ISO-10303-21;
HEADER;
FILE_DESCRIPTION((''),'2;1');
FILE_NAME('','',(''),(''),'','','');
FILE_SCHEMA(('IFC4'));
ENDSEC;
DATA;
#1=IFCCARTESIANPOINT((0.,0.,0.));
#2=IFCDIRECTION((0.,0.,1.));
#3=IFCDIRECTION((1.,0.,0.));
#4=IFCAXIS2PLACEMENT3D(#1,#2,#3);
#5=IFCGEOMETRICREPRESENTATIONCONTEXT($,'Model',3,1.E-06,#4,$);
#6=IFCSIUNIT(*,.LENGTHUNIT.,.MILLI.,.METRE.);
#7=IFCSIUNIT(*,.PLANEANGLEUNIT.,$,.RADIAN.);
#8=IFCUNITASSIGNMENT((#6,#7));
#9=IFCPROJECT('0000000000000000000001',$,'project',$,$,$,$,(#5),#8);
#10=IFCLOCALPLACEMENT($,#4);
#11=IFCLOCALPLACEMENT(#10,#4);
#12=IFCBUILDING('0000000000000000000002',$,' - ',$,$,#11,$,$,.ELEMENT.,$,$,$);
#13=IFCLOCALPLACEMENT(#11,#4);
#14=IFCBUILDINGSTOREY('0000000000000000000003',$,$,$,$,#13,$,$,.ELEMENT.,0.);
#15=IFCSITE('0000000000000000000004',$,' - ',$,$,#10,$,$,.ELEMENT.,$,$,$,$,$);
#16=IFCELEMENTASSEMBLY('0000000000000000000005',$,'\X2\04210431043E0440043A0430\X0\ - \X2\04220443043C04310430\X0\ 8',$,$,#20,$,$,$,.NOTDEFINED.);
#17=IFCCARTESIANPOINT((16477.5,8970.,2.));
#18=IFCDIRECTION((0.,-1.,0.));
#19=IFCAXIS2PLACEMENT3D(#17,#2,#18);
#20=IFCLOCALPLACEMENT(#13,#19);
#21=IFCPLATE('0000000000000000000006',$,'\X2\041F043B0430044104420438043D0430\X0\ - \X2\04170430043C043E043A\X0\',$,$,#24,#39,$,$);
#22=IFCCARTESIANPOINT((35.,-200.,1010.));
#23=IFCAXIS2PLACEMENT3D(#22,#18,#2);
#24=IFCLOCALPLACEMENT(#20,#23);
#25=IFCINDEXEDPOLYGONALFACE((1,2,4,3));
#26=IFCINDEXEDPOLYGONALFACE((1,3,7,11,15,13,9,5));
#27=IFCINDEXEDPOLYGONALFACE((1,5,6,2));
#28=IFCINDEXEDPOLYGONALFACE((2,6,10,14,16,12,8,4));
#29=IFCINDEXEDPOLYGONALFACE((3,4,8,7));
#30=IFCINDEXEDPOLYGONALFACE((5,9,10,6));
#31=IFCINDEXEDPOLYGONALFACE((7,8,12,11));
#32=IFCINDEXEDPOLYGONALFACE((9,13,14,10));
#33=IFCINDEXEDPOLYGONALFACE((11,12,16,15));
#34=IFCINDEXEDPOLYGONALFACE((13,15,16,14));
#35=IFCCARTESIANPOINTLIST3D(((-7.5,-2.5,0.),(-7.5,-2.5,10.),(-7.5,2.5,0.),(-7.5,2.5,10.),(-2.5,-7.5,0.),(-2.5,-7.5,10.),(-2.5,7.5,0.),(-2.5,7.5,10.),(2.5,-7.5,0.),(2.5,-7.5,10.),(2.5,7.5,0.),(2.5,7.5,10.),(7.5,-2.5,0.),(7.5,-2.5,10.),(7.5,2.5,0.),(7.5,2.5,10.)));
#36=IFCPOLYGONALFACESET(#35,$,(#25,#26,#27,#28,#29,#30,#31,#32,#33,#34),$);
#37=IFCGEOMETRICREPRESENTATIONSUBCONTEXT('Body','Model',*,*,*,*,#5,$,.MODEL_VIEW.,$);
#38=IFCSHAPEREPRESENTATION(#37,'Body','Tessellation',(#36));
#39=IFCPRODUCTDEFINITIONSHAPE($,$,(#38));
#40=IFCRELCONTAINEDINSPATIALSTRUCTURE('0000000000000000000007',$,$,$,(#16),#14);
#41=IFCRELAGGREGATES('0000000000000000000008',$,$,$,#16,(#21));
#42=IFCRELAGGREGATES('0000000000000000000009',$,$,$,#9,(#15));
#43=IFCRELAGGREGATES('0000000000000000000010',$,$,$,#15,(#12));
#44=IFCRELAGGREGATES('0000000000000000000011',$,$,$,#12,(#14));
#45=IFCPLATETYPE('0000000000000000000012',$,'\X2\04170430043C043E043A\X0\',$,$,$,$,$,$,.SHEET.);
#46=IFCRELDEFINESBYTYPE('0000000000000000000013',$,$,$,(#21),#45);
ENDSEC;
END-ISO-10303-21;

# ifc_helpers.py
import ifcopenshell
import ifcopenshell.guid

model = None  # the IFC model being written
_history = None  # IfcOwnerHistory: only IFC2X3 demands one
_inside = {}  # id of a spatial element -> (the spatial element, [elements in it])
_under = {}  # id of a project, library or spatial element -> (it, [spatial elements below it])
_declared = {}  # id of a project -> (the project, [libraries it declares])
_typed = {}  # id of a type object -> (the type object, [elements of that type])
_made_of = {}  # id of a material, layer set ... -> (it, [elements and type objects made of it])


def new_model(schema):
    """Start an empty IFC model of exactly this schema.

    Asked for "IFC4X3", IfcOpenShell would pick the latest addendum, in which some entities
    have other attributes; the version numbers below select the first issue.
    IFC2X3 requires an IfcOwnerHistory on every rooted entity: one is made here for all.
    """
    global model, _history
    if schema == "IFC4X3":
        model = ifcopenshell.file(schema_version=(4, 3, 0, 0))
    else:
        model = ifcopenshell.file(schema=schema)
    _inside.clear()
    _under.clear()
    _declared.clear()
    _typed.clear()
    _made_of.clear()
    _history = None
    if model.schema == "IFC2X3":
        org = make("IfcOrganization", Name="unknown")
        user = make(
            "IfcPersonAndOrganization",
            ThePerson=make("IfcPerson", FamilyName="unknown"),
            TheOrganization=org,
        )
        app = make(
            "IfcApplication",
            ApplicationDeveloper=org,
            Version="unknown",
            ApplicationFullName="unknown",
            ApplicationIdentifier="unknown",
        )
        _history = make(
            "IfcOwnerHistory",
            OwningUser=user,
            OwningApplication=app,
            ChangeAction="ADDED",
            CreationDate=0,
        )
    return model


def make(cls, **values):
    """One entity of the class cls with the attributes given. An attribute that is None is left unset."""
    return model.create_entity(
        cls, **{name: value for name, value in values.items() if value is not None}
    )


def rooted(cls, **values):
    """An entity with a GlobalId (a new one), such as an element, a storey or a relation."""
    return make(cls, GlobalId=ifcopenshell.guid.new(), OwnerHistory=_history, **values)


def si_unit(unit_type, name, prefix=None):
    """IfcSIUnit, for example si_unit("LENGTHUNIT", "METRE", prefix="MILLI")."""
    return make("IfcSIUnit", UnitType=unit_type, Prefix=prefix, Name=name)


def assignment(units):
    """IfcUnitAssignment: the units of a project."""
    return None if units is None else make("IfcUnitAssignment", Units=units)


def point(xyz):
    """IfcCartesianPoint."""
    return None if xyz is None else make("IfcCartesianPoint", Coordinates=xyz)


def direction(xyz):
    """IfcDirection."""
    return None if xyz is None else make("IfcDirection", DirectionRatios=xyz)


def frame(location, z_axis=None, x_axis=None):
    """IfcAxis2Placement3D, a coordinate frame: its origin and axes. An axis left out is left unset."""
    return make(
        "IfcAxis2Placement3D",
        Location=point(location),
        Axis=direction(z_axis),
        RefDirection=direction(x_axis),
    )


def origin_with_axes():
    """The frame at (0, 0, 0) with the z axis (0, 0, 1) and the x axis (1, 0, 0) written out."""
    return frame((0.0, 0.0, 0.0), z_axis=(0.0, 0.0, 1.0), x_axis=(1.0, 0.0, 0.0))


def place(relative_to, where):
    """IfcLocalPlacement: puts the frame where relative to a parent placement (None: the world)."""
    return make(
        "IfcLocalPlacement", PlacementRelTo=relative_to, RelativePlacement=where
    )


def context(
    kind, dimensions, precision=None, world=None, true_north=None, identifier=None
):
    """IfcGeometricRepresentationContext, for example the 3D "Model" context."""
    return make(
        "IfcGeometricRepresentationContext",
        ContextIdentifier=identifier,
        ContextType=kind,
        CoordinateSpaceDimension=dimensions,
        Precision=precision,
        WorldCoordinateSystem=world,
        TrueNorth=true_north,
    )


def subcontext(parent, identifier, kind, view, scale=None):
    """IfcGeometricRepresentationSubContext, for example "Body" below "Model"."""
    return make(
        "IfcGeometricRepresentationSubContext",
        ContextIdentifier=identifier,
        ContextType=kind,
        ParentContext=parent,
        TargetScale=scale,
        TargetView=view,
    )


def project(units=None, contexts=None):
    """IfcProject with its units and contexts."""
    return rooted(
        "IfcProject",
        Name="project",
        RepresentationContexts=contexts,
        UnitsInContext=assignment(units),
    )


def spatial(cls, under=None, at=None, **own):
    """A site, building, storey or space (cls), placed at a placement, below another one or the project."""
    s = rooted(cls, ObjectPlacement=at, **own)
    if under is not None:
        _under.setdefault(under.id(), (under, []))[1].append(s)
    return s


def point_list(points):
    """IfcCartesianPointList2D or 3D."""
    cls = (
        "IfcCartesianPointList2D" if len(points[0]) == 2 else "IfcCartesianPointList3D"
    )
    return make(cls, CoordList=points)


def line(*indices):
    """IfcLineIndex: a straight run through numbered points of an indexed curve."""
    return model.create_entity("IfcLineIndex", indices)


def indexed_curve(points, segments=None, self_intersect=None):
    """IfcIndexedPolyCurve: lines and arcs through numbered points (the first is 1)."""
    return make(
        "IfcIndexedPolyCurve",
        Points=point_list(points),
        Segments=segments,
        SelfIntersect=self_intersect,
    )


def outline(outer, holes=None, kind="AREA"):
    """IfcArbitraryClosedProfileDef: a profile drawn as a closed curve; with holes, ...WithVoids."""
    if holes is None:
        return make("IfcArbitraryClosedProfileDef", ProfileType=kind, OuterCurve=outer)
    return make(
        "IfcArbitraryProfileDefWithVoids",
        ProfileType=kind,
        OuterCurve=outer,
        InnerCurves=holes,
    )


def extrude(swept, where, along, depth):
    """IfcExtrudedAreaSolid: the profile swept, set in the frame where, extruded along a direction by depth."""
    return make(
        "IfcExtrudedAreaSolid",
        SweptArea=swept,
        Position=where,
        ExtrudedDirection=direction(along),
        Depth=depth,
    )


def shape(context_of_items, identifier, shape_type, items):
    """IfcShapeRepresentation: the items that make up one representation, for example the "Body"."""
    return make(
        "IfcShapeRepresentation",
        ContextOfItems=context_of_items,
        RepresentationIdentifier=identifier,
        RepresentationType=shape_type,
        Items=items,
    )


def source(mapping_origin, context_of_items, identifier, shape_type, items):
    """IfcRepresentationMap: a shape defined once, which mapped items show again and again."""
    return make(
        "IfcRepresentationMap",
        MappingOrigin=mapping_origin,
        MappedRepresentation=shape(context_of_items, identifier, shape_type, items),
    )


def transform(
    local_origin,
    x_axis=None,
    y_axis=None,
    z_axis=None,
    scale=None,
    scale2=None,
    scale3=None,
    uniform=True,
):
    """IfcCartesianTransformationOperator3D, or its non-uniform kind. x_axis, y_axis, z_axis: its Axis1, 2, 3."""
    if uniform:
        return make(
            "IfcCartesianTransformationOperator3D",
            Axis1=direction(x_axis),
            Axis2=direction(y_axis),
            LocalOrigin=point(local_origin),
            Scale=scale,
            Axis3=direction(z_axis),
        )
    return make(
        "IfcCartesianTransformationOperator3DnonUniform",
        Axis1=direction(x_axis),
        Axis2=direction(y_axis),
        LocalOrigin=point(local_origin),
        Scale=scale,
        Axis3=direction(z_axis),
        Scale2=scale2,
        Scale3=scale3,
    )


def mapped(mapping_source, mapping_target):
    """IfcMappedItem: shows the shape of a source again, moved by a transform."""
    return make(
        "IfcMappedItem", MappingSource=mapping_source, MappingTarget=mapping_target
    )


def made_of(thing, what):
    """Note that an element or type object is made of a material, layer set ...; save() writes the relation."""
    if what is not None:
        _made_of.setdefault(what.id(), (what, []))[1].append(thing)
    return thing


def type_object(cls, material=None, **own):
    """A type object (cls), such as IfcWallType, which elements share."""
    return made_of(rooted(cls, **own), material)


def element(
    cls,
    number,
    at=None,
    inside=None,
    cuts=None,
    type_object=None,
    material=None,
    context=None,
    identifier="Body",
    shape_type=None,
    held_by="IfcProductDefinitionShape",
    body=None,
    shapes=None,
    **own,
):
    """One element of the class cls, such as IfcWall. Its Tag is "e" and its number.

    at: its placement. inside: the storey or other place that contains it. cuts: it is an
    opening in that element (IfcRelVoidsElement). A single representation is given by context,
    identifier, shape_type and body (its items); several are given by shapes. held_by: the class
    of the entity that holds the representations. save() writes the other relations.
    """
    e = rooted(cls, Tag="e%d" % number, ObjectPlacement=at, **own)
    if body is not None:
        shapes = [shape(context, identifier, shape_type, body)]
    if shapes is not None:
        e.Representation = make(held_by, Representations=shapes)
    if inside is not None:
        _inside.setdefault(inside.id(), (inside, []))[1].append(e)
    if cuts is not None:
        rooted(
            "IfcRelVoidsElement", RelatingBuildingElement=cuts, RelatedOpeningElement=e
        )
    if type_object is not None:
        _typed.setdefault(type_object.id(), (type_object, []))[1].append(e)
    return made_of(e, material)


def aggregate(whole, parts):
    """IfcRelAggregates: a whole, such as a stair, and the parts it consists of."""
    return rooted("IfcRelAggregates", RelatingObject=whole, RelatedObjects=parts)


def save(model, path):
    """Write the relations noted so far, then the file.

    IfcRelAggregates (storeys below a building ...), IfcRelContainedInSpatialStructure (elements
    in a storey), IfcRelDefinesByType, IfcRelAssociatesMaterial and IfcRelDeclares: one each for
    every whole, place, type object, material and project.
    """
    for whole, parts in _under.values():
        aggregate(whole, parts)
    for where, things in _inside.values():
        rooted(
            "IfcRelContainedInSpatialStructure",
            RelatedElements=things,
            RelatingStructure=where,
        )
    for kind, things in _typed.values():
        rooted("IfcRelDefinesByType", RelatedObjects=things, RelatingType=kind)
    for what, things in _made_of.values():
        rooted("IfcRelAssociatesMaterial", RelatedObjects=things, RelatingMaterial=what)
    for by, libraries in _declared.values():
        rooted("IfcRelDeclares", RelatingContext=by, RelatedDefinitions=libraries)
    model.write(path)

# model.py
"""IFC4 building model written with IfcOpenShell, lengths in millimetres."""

from ifc_helpers import new_model, si_unit, frame, origin_with_axes, place, context, subcontext, project, spatial, line, indexed_curve, outline, extrude, source, transform, mapped, type_object, element, aggregate, save


model = new_model("IFC4")

# Units and contexts
model_context = context("Model", 3, precision=1e-06, world=origin_with_axes())
body_context = subcontext(model_context, "Body", "Model", "MODEL_VIEW")
ifc_project = project(units=[si_unit("LENGTHUNIT", "METRE", prefix="MILLI"), si_unit("PLANEANGLEUNIT", "RADIAN")], contexts=[model_context])

# Site, building, storey
site_placement = place(None, origin_with_axes())
site = spatial("IfcSite", under=ifc_project, at=site_placement, Name=" - ", CompositionType="ELEMENT")
building_placement = place(site_placement, origin_with_axes())
building = spatial("IfcBuilding", under=site, at=building_placement, Name=" - ", CompositionType="ELEMENT")
storey_placement = place(building_placement, origin_with_axes())
storey = spatial("IfcBuildingStorey", under=building, at=storey_placement, CompositionType="ELEMENT", Elevation=0.0)

# Element assembly
assembly_1_placement = place(storey_placement, frame((16477.5, 8970.0, 2.0), z_axis=(0.0, 0.0, 1.0), x_axis=(0.0, -1.0, 0.0)))
assembly_1 = element("IfcElementAssembly", 1, at=assembly_1_placement, inside=storey, Name="Сборка - Тумба 8", PredefinedType="NOTDEFINED")

# Plate
plate_type_1 = type_object("IfcPlateType", Name="Замок", PredefinedType="SHEET")
shared_shape_1 = source(origin_with_axes(), body_context, "Body", "SweptSolid", [
    extrude(outline(indexed_curve([(-2.5, 7.5), (-7.5, 2.5), (-7.5, -2.5), (-2.5, -7.5), (2.5, -7.5), (7.5, -2.5), (7.5, 2.5), (2.5, 7.5)], segments=[line(1, 2), line(2, 3), line(3, 4), line(4, 5), line(5, 6), line(6, 7), line(7, 8), line(8, 1)])), origin_with_axes(), (0.0, 0.0, 1.0), 10.0),
])
plate_1_placement = place(assembly_1_placement, frame((35.0, -200.0, 1010.0), z_axis=(0.0, -1.0, 0.0), x_axis=(0.0, 0.0, 1.0)))
plate_1 = element("IfcPlate", 2, at=plate_1_placement, type_object=plate_type_1, Name="Пластина - Замок", context=body_context, shape_type="MappedRepresentation", body=[
    mapped(shared_shape_1, transform((0.0, 0.0, 0.0), x_axis=(1.0, 0.0, 0.0), y_axis=(0.0, 1.0, 0.0), z_axis=(0.0, 0.0, 1.0), scale=1.0)),
])
aggregate(assembly_1, [plate_1])

save(model, "model.ifc")
